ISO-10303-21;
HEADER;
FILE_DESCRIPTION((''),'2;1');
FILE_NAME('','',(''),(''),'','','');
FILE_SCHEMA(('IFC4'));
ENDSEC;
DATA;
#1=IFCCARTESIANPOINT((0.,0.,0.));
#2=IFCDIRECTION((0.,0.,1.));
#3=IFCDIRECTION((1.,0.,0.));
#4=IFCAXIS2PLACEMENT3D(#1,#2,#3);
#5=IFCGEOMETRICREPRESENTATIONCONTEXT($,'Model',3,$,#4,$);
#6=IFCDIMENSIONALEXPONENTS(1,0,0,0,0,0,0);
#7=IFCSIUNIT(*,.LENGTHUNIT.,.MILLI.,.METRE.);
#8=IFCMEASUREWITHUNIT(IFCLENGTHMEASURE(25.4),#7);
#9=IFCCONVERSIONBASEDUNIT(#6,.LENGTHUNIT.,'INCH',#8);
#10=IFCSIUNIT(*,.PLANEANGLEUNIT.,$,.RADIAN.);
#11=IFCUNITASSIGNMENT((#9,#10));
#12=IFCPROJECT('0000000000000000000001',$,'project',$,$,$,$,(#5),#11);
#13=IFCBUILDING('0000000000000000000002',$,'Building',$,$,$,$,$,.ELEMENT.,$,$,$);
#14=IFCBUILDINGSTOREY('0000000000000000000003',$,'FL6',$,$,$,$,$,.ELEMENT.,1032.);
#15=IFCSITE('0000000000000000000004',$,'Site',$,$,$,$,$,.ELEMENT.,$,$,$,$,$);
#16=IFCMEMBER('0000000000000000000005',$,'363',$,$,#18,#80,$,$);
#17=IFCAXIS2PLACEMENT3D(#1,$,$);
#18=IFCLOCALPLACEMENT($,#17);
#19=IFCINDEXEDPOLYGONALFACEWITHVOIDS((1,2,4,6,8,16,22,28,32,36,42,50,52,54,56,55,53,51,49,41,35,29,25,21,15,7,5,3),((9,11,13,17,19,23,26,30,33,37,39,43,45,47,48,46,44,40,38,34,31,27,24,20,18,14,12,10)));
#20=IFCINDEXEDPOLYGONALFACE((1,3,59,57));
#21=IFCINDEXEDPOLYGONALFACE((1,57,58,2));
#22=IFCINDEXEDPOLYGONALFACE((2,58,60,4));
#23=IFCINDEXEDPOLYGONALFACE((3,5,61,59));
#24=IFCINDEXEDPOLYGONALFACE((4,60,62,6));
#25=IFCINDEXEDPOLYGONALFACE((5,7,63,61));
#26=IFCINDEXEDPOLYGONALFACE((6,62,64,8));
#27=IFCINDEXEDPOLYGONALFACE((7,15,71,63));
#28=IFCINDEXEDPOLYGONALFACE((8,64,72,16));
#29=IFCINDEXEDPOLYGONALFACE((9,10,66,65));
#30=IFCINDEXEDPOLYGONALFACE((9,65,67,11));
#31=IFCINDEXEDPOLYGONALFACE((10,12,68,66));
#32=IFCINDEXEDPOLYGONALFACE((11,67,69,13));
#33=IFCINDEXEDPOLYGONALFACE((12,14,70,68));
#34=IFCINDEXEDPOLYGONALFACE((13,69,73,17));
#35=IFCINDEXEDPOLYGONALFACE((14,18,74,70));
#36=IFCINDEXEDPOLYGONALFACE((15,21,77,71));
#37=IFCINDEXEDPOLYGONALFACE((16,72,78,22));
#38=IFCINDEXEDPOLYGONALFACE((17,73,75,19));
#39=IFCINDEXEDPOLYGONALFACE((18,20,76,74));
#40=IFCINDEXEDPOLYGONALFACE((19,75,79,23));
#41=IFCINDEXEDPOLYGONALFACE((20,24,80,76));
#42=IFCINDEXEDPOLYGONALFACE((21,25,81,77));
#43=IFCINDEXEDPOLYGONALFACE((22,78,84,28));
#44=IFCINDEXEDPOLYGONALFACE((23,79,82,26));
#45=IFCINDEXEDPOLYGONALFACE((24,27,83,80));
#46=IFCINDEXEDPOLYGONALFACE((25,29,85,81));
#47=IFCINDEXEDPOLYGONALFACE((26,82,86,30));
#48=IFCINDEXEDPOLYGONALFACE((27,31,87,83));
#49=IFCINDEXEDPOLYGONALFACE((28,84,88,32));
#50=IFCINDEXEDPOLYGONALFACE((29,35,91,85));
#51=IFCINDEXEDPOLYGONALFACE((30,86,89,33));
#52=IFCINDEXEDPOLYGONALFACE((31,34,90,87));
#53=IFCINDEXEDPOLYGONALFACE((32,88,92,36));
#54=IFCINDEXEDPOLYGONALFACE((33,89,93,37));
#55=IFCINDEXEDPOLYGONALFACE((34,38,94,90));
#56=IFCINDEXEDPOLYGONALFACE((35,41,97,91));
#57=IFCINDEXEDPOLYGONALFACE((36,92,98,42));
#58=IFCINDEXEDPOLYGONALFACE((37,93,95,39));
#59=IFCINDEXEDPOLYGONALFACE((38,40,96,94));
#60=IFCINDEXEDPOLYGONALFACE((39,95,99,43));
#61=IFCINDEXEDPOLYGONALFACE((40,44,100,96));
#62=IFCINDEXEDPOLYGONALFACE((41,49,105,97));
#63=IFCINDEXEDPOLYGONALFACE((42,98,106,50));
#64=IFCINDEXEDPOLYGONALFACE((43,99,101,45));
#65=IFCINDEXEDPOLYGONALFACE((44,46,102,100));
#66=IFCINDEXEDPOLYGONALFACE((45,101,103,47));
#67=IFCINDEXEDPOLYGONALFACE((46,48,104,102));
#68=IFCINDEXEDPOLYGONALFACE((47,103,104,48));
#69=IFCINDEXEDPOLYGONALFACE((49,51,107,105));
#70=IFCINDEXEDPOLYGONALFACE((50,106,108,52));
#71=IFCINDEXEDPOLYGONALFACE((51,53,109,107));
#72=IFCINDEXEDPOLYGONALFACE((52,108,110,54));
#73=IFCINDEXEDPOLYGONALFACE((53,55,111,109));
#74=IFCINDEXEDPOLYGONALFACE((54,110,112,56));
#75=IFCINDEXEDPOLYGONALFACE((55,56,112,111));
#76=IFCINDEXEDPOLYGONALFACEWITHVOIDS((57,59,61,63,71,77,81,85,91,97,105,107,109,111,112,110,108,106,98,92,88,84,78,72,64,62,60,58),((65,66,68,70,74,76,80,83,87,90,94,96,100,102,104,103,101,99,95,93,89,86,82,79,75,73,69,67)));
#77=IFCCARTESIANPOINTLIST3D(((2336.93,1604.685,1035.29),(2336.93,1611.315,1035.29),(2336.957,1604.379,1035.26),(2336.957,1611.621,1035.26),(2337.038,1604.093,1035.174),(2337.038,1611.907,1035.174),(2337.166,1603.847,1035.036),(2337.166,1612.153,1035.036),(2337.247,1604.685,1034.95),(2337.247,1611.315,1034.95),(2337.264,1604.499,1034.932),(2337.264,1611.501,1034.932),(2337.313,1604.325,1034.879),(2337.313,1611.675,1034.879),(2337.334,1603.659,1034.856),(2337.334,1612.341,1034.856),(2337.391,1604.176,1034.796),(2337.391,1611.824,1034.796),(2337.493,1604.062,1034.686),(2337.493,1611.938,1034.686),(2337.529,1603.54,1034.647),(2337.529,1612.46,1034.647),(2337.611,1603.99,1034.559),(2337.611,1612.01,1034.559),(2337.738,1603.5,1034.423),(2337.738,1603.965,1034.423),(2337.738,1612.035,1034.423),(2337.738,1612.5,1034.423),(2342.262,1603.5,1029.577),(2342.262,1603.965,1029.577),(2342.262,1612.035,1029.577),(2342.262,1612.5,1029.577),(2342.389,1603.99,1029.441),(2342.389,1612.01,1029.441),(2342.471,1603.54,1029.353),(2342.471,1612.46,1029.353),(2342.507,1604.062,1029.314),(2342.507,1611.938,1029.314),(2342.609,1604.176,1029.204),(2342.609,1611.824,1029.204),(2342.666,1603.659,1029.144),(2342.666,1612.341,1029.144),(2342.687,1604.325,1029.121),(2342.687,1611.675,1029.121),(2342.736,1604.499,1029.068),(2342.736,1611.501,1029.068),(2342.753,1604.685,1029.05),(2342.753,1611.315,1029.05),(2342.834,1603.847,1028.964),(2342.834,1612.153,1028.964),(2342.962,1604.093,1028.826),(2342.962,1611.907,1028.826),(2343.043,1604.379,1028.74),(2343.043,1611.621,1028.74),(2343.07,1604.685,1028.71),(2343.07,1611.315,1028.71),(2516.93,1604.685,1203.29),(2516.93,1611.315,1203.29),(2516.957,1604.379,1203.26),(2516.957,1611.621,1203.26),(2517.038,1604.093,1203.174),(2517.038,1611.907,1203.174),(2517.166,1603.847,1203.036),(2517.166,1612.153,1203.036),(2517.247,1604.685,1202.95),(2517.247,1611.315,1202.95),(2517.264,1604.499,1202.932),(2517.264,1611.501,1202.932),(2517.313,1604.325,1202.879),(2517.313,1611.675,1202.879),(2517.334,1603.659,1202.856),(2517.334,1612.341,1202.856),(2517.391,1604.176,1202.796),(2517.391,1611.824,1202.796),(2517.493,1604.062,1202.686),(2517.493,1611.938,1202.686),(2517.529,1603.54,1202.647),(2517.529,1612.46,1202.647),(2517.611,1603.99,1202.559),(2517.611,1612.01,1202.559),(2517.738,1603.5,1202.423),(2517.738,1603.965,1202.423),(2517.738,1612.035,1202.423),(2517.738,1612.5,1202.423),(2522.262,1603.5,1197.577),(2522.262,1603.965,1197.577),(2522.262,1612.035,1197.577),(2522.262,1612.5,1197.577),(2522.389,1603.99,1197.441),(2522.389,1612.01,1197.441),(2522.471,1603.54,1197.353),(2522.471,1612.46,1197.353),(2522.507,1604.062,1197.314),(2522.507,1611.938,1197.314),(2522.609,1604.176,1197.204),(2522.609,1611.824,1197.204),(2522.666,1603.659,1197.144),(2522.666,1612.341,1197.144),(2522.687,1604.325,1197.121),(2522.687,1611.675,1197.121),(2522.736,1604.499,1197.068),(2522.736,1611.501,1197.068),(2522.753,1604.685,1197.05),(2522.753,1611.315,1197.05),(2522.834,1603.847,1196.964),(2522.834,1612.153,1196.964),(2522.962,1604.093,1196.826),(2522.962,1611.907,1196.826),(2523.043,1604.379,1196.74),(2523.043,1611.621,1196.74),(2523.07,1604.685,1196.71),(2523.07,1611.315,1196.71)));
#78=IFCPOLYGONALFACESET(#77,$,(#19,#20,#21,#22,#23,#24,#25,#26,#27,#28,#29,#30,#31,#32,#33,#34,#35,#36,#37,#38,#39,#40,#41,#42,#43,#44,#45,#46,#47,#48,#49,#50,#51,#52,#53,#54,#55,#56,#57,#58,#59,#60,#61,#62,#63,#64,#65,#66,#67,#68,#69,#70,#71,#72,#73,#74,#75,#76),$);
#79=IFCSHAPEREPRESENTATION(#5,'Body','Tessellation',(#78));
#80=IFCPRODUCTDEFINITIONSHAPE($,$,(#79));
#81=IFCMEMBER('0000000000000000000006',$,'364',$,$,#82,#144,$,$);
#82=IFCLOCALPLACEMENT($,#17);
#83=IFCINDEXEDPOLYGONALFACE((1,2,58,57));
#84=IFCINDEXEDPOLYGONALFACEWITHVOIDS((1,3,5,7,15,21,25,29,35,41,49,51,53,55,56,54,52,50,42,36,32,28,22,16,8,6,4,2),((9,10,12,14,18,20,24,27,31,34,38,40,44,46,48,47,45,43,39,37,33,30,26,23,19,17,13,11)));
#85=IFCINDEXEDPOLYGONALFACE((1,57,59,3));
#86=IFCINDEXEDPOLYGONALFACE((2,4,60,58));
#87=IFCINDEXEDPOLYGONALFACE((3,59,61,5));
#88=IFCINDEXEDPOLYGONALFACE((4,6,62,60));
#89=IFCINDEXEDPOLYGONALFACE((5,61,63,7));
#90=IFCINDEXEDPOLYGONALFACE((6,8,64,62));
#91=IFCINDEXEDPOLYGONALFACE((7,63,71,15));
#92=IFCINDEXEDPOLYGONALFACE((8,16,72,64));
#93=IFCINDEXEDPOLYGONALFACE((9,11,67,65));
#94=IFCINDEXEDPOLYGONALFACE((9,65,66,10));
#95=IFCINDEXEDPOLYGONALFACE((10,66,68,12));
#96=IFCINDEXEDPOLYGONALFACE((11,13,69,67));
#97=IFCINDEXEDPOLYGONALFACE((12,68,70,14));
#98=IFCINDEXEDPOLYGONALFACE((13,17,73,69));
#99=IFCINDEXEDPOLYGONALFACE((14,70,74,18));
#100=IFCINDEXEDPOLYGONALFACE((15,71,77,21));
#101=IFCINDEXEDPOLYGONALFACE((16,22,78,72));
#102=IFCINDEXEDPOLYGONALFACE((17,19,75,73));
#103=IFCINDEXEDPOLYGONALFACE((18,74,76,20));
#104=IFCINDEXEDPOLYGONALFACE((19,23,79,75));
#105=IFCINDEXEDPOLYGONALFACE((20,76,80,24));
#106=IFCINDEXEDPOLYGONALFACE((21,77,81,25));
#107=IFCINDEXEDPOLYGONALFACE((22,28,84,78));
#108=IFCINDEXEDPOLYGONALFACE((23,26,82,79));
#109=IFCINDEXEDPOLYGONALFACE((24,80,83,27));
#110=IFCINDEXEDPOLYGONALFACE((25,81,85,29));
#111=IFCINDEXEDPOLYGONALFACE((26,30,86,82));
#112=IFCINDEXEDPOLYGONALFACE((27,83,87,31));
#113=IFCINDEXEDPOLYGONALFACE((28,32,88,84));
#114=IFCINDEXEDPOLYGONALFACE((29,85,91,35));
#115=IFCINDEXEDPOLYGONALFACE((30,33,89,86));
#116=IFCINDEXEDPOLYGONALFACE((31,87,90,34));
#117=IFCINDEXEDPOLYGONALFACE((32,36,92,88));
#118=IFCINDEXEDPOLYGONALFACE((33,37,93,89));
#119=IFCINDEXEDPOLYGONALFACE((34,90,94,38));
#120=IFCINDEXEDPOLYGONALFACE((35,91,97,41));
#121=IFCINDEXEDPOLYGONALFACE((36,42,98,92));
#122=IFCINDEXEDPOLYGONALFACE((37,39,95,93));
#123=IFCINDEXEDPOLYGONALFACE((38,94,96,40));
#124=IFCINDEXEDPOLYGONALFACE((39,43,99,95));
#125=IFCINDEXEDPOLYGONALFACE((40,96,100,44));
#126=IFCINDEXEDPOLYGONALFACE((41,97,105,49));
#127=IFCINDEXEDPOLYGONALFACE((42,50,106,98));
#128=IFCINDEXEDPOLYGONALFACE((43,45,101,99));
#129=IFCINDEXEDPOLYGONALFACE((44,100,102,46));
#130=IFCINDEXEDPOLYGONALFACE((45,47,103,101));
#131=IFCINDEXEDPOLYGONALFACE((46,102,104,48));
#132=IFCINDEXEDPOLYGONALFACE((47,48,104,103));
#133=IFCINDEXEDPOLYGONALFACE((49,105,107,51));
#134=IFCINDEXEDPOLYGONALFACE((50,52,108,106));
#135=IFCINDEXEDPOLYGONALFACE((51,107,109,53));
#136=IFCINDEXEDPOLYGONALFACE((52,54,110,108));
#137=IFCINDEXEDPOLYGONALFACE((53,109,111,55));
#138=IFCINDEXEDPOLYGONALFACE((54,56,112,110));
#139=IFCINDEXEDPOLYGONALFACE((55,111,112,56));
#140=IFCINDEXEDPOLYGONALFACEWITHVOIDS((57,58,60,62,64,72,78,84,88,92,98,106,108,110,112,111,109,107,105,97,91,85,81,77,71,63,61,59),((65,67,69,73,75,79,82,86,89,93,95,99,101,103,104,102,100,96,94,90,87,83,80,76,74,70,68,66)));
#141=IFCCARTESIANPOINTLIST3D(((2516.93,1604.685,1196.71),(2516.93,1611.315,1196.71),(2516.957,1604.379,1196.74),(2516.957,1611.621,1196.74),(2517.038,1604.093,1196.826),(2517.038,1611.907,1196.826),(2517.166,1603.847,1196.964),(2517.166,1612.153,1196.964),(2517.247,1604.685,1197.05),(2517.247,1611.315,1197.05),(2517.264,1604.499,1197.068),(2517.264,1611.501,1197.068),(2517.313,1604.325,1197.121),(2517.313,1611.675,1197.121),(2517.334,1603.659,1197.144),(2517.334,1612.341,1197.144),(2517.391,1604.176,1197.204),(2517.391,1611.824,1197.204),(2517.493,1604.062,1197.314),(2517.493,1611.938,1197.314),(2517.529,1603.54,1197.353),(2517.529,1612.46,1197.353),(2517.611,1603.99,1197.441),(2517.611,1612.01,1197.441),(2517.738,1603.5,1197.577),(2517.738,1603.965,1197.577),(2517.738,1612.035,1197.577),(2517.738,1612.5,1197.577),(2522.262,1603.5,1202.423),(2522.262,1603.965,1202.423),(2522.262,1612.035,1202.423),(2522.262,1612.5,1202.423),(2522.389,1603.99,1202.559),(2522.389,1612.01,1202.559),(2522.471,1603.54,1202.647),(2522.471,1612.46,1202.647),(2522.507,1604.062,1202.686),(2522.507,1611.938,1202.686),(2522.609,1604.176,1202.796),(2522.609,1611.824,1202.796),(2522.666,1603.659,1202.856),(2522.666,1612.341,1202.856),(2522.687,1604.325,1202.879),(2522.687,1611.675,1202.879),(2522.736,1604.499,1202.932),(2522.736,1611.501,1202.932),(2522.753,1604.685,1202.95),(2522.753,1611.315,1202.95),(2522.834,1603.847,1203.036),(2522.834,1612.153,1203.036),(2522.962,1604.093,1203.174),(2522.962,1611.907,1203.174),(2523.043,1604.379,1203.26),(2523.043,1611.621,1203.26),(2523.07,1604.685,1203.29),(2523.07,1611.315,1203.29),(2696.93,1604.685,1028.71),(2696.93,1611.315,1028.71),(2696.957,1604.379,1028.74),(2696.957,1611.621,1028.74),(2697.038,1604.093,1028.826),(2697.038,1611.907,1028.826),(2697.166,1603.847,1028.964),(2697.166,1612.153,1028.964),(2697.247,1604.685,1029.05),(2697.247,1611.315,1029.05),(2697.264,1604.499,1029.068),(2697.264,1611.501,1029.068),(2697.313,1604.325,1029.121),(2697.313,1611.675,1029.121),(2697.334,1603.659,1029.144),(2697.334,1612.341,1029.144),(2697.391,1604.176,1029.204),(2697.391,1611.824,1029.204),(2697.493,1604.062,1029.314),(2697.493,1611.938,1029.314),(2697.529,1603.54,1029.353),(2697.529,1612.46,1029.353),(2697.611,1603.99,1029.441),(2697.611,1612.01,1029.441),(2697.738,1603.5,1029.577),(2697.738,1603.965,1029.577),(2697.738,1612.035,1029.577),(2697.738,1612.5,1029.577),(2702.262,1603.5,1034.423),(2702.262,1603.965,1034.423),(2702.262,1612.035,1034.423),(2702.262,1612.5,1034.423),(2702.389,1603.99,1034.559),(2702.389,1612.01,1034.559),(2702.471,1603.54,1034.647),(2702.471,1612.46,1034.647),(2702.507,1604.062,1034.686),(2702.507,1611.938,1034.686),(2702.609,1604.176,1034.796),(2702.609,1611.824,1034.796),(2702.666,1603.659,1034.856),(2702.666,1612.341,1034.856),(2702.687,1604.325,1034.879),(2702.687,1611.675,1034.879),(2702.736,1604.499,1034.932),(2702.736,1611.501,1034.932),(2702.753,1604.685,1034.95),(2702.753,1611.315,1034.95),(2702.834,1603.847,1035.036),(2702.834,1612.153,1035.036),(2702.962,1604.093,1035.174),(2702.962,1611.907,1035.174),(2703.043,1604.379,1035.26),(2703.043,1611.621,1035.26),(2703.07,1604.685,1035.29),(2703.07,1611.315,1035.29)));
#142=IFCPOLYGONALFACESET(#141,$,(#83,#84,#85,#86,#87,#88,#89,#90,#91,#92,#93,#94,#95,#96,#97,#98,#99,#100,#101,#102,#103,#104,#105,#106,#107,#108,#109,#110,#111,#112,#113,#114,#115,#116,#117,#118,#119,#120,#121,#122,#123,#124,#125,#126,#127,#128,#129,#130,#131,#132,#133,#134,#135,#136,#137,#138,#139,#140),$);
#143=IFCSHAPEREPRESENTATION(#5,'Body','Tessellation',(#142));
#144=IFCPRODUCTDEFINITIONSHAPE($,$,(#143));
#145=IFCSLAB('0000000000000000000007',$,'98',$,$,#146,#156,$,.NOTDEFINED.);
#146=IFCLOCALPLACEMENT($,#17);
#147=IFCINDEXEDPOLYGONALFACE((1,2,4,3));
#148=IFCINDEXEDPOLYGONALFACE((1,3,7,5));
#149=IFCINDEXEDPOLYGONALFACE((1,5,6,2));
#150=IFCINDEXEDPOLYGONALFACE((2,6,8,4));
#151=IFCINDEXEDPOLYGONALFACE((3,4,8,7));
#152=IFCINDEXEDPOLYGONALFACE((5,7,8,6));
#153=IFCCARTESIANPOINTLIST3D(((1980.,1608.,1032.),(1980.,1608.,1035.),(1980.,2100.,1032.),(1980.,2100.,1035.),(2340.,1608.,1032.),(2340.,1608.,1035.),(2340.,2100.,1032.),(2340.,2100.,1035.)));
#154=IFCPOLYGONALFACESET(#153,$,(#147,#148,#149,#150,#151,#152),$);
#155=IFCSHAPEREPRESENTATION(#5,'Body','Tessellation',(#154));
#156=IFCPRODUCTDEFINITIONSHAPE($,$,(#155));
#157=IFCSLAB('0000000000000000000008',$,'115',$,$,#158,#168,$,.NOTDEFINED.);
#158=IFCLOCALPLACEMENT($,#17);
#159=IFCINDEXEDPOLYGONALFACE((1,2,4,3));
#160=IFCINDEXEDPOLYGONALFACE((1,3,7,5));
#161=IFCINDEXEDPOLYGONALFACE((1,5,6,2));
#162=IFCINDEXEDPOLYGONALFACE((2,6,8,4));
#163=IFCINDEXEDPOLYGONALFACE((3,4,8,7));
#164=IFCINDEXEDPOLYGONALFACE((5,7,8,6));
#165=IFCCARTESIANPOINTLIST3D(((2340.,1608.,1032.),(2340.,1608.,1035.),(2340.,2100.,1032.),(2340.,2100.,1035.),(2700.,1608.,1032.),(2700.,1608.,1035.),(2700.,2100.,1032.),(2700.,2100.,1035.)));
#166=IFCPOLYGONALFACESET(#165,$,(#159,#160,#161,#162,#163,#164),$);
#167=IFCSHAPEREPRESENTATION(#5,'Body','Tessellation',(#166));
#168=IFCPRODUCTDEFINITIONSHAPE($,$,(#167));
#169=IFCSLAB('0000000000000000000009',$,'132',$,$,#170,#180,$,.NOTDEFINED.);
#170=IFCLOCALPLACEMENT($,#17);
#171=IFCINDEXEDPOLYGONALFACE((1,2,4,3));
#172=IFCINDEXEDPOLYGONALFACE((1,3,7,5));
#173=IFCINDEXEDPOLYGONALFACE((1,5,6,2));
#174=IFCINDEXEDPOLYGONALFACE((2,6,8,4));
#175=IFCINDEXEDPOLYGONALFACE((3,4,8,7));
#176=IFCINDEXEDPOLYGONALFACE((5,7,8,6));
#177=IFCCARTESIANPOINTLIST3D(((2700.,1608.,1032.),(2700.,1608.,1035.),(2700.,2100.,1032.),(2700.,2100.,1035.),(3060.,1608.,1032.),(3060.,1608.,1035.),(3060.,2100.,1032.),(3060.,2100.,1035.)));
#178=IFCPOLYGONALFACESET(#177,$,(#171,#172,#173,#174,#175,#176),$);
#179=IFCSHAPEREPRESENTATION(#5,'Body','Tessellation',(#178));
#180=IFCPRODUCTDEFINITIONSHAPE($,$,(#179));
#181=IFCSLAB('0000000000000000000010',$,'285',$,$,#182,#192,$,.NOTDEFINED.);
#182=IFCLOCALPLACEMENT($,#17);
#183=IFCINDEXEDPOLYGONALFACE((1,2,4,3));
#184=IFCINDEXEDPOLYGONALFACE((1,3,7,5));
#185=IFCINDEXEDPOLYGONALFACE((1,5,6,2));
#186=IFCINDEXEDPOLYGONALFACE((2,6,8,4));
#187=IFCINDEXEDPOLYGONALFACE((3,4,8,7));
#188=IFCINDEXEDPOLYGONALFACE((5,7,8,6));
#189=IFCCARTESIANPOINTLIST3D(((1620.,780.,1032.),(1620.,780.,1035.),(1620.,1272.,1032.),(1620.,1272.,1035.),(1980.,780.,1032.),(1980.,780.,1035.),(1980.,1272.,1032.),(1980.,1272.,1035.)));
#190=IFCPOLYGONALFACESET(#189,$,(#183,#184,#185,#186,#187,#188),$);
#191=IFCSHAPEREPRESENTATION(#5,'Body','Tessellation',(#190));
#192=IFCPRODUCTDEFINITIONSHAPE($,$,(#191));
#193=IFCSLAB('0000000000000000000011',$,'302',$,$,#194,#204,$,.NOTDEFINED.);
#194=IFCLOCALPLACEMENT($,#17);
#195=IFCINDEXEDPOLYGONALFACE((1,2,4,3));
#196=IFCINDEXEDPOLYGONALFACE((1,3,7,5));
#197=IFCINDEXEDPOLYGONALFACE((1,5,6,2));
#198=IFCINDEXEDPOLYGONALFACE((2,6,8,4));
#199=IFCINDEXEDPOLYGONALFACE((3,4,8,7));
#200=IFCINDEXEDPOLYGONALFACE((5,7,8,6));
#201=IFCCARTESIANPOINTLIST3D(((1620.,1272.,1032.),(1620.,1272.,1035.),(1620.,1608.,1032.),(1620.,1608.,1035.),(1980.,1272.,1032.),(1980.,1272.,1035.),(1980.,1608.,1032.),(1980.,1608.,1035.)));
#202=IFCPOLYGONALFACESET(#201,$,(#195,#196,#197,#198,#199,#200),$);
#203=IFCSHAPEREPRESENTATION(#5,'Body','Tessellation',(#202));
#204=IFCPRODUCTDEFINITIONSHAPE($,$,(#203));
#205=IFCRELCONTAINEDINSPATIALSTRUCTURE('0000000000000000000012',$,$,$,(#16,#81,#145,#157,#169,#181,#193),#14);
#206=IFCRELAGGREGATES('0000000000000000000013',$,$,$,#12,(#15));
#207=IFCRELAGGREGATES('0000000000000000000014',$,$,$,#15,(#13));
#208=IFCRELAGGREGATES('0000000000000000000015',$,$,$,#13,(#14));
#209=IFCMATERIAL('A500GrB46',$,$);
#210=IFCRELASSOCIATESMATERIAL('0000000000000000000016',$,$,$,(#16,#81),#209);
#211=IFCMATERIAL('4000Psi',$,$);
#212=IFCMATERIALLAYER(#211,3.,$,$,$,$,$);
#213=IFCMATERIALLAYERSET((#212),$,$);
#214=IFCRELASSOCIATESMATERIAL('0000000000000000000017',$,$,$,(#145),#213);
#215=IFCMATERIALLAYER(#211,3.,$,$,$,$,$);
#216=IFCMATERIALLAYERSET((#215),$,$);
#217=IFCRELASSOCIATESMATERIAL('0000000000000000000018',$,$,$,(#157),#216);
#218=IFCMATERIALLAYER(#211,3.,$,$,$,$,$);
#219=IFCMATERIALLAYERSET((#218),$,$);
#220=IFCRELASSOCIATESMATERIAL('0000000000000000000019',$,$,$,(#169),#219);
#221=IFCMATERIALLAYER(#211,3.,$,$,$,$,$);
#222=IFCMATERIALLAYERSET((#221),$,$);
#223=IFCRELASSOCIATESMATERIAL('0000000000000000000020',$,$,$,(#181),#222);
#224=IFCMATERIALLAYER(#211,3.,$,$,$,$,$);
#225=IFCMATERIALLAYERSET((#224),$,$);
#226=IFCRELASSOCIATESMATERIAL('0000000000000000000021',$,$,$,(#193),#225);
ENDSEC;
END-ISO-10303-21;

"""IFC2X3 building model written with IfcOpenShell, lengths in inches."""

from ifc_helpers import new_model, entity, si_unit, converted_unit, frame, origin_with_axes, origin_2d_with_axis, place, context, project, spatial, polyline, hollow_rectangle, outline, extrude, material, layer, layer_set, layer_usage, element, save


model = new_model("IFC2X3")

# Units and contexts
model_context = context("Model", 3, world=origin_with_axes())
ifc_project = project(units=[converted_unit("LENGTHUNIT", "INCH", entity("IfcLengthMeasure", 25.4), si_unit("LENGTHUNIT", "METRE", prefix="MILLI"), dimensions=[1, 0, 0, 0, 0, 0, 0]), si_unit("PLANEANGLEUNIT", "RADIAN")], contexts=[model_context])

# Site, building, storey
site = spatial("IfcSite", under=ifc_project, Name="Site", CompositionType="ELEMENT")
building = spatial("IfcBuilding", under=site, Name="Building", CompositionType="ELEMENT")
storey = spatial("IfcBuildingStorey", under=building, Name="FL6", CompositionType="ELEMENT", Elevation=1032.0)

# Members
ifc_material_1 = material(Name="A500GrB46")
for number, where, z_axis, x_axis, name in (
    (1, (2340.0, 1608.0, 1032.0), (0.731055, 0.0, 0.682318), (0.0, 1.0, 0.0), "363"),
    (2, (2700.0, 1608.0, 1032.0), (-0.731055, 0.0, 0.682318), (0.0, -1.0, 0.0), "364"),
):
    element("IfcMember", number, at=place(None, frame(where, z_axis=z_axis, x_axis=x_axis)), inside=storey, material=ifc_material_1, Name=name, context=model_context, shape_type="SweptSolid", body=[
        extrude(hollow_rectangle(XDim=9.0, YDim=9.0, WallThickness=0.465, InnerFilletRadius=0.72, OuterFilletRadius=1.185, at=origin_2d_with_axis()), origin_with_axes(), (0.0, 0.0, 1.0), 246.219),
    ])

# Slabs
ifc_material_2 = material(Name="4000Psi")
ifc_layer_1 = layer(ifc_material_2, 3.0)
ifc_layer_set_1 = layer_set([ifc_layer_1])
ifc_layer_usage_1 = layer_usage(ifc_layer_set_1, "AXIS2", "POSITIVE", -3.0)
slab_1_placement = place(None, frame((1980.0, 1608.0, 1032.0), z_axis=(0.0, 0.0, 1.0), x_axis=(1.0, 0.0, 0.0)))
element("IfcSlab", 3, at=slab_1_placement, inside=storey, material=ifc_layer_usage_1, Name="98", PredefinedType="NOTDEFINED", context=model_context, shape_type="SweptSolid", body=[
    extrude(outline(polyline([(0.0, 0.0), (360.0, 0.0), (360.0, 492.0), (0.0, 492.0), (0.0, 0.0)])), origin_with_axes(), (0.0, 0.0, 1.0), 3.0),
])
ifc_layer_2 = layer(ifc_material_2, 3.0)
ifc_layer_set_2 = layer_set([ifc_layer_2])
ifc_layer_usage_2 = layer_usage(ifc_layer_set_2, "AXIS2", "POSITIVE", -3.0)
slab_2_placement = place(None, frame((2340.0, 1608.0, 1032.0), z_axis=(0.0, 0.0, 1.0), x_axis=(1.0, 0.0, 0.0)))
element("IfcSlab", 4, at=slab_2_placement, inside=storey, material=ifc_layer_usage_2, Name="115", PredefinedType="NOTDEFINED", context=model_context, shape_type="SweptSolid", body=[
    extrude(outline(polyline([(0.0, 0.0), (360.0, 0.0), (360.0, 492.0), (0.0, 492.0), (0.0, 0.0)])), origin_with_axes(), (0.0, 0.0, 1.0), 3.0),
])
ifc_layer_3 = layer(ifc_material_2, 3.0)
ifc_layer_set_3 = layer_set([ifc_layer_3])
ifc_layer_usage_3 = layer_usage(ifc_layer_set_3, "AXIS2", "POSITIVE", -3.0)
slab_3_placement = place(None, frame((2700.0, 1608.0, 1032.0), z_axis=(0.0, 0.0, 1.0), x_axis=(1.0, 0.0, 0.0)))
element("IfcSlab", 5, at=slab_3_placement, inside=storey, material=ifc_layer_usage_3, Name="132", PredefinedType="NOTDEFINED", context=model_context, shape_type="SweptSolid", body=[
    extrude(outline(polyline([(0.0, 0.0), (360.0, 0.0), (360.0, 492.0), (0.0, 492.0), (0.0, 0.0)])), origin_with_axes(), (0.0, 0.0, 1.0), 3.0),
])
ifc_layer_4 = layer(ifc_material_2, 3.0)
ifc_layer_set_4 = layer_set([ifc_layer_4])
ifc_layer_usage_4 = layer_usage(ifc_layer_set_4, "AXIS2", "POSITIVE", -3.0)
slab_4_placement = place(None, frame((1620.0, 780.0, 1032.0), z_axis=(0.0, 0.0, 1.0), x_axis=(1.0, 0.0, 0.0)))
element("IfcSlab", 6, at=slab_4_placement, inside=storey, material=ifc_layer_usage_4, Name="285", PredefinedType="NOTDEFINED", context=model_context, shape_type="SweptSolid", body=[
    extrude(outline(polyline([(0.0, 0.0), (360.0, 0.0), (360.0, 492.0), (0.0, 492.0), (0.0, 0.0)])), origin_with_axes(), (0.0, 0.0, 1.0), 3.0),
])
ifc_layer_5 = layer(ifc_material_2, 3.0)
ifc_layer_set_5 = layer_set([ifc_layer_5])
ifc_layer_usage_5 = layer_usage(ifc_layer_set_5, "AXIS2", "POSITIVE", -3.0)
slab_5_placement = place(None, frame((1620.0, 1272.0, 1032.0), z_axis=(0.0, 0.0, 1.0), x_axis=(1.0, 0.0, 0.0)))
element("IfcSlab", 7, at=slab_5_placement, inside=storey, material=ifc_layer_usage_5, Name="302", PredefinedType="NOTDEFINED", context=model_context, shape_type="SweptSolid", body=[
    extrude(outline(polyline([(0.0, 0.0), (360.0, 0.0), (360.0, 336.0), (0.0, 336.0), (0.0, 0.0)])), origin_with_axes(), (0.0, 0.0, 1.0), 3.0),
])

save(model, "model.ifc")
